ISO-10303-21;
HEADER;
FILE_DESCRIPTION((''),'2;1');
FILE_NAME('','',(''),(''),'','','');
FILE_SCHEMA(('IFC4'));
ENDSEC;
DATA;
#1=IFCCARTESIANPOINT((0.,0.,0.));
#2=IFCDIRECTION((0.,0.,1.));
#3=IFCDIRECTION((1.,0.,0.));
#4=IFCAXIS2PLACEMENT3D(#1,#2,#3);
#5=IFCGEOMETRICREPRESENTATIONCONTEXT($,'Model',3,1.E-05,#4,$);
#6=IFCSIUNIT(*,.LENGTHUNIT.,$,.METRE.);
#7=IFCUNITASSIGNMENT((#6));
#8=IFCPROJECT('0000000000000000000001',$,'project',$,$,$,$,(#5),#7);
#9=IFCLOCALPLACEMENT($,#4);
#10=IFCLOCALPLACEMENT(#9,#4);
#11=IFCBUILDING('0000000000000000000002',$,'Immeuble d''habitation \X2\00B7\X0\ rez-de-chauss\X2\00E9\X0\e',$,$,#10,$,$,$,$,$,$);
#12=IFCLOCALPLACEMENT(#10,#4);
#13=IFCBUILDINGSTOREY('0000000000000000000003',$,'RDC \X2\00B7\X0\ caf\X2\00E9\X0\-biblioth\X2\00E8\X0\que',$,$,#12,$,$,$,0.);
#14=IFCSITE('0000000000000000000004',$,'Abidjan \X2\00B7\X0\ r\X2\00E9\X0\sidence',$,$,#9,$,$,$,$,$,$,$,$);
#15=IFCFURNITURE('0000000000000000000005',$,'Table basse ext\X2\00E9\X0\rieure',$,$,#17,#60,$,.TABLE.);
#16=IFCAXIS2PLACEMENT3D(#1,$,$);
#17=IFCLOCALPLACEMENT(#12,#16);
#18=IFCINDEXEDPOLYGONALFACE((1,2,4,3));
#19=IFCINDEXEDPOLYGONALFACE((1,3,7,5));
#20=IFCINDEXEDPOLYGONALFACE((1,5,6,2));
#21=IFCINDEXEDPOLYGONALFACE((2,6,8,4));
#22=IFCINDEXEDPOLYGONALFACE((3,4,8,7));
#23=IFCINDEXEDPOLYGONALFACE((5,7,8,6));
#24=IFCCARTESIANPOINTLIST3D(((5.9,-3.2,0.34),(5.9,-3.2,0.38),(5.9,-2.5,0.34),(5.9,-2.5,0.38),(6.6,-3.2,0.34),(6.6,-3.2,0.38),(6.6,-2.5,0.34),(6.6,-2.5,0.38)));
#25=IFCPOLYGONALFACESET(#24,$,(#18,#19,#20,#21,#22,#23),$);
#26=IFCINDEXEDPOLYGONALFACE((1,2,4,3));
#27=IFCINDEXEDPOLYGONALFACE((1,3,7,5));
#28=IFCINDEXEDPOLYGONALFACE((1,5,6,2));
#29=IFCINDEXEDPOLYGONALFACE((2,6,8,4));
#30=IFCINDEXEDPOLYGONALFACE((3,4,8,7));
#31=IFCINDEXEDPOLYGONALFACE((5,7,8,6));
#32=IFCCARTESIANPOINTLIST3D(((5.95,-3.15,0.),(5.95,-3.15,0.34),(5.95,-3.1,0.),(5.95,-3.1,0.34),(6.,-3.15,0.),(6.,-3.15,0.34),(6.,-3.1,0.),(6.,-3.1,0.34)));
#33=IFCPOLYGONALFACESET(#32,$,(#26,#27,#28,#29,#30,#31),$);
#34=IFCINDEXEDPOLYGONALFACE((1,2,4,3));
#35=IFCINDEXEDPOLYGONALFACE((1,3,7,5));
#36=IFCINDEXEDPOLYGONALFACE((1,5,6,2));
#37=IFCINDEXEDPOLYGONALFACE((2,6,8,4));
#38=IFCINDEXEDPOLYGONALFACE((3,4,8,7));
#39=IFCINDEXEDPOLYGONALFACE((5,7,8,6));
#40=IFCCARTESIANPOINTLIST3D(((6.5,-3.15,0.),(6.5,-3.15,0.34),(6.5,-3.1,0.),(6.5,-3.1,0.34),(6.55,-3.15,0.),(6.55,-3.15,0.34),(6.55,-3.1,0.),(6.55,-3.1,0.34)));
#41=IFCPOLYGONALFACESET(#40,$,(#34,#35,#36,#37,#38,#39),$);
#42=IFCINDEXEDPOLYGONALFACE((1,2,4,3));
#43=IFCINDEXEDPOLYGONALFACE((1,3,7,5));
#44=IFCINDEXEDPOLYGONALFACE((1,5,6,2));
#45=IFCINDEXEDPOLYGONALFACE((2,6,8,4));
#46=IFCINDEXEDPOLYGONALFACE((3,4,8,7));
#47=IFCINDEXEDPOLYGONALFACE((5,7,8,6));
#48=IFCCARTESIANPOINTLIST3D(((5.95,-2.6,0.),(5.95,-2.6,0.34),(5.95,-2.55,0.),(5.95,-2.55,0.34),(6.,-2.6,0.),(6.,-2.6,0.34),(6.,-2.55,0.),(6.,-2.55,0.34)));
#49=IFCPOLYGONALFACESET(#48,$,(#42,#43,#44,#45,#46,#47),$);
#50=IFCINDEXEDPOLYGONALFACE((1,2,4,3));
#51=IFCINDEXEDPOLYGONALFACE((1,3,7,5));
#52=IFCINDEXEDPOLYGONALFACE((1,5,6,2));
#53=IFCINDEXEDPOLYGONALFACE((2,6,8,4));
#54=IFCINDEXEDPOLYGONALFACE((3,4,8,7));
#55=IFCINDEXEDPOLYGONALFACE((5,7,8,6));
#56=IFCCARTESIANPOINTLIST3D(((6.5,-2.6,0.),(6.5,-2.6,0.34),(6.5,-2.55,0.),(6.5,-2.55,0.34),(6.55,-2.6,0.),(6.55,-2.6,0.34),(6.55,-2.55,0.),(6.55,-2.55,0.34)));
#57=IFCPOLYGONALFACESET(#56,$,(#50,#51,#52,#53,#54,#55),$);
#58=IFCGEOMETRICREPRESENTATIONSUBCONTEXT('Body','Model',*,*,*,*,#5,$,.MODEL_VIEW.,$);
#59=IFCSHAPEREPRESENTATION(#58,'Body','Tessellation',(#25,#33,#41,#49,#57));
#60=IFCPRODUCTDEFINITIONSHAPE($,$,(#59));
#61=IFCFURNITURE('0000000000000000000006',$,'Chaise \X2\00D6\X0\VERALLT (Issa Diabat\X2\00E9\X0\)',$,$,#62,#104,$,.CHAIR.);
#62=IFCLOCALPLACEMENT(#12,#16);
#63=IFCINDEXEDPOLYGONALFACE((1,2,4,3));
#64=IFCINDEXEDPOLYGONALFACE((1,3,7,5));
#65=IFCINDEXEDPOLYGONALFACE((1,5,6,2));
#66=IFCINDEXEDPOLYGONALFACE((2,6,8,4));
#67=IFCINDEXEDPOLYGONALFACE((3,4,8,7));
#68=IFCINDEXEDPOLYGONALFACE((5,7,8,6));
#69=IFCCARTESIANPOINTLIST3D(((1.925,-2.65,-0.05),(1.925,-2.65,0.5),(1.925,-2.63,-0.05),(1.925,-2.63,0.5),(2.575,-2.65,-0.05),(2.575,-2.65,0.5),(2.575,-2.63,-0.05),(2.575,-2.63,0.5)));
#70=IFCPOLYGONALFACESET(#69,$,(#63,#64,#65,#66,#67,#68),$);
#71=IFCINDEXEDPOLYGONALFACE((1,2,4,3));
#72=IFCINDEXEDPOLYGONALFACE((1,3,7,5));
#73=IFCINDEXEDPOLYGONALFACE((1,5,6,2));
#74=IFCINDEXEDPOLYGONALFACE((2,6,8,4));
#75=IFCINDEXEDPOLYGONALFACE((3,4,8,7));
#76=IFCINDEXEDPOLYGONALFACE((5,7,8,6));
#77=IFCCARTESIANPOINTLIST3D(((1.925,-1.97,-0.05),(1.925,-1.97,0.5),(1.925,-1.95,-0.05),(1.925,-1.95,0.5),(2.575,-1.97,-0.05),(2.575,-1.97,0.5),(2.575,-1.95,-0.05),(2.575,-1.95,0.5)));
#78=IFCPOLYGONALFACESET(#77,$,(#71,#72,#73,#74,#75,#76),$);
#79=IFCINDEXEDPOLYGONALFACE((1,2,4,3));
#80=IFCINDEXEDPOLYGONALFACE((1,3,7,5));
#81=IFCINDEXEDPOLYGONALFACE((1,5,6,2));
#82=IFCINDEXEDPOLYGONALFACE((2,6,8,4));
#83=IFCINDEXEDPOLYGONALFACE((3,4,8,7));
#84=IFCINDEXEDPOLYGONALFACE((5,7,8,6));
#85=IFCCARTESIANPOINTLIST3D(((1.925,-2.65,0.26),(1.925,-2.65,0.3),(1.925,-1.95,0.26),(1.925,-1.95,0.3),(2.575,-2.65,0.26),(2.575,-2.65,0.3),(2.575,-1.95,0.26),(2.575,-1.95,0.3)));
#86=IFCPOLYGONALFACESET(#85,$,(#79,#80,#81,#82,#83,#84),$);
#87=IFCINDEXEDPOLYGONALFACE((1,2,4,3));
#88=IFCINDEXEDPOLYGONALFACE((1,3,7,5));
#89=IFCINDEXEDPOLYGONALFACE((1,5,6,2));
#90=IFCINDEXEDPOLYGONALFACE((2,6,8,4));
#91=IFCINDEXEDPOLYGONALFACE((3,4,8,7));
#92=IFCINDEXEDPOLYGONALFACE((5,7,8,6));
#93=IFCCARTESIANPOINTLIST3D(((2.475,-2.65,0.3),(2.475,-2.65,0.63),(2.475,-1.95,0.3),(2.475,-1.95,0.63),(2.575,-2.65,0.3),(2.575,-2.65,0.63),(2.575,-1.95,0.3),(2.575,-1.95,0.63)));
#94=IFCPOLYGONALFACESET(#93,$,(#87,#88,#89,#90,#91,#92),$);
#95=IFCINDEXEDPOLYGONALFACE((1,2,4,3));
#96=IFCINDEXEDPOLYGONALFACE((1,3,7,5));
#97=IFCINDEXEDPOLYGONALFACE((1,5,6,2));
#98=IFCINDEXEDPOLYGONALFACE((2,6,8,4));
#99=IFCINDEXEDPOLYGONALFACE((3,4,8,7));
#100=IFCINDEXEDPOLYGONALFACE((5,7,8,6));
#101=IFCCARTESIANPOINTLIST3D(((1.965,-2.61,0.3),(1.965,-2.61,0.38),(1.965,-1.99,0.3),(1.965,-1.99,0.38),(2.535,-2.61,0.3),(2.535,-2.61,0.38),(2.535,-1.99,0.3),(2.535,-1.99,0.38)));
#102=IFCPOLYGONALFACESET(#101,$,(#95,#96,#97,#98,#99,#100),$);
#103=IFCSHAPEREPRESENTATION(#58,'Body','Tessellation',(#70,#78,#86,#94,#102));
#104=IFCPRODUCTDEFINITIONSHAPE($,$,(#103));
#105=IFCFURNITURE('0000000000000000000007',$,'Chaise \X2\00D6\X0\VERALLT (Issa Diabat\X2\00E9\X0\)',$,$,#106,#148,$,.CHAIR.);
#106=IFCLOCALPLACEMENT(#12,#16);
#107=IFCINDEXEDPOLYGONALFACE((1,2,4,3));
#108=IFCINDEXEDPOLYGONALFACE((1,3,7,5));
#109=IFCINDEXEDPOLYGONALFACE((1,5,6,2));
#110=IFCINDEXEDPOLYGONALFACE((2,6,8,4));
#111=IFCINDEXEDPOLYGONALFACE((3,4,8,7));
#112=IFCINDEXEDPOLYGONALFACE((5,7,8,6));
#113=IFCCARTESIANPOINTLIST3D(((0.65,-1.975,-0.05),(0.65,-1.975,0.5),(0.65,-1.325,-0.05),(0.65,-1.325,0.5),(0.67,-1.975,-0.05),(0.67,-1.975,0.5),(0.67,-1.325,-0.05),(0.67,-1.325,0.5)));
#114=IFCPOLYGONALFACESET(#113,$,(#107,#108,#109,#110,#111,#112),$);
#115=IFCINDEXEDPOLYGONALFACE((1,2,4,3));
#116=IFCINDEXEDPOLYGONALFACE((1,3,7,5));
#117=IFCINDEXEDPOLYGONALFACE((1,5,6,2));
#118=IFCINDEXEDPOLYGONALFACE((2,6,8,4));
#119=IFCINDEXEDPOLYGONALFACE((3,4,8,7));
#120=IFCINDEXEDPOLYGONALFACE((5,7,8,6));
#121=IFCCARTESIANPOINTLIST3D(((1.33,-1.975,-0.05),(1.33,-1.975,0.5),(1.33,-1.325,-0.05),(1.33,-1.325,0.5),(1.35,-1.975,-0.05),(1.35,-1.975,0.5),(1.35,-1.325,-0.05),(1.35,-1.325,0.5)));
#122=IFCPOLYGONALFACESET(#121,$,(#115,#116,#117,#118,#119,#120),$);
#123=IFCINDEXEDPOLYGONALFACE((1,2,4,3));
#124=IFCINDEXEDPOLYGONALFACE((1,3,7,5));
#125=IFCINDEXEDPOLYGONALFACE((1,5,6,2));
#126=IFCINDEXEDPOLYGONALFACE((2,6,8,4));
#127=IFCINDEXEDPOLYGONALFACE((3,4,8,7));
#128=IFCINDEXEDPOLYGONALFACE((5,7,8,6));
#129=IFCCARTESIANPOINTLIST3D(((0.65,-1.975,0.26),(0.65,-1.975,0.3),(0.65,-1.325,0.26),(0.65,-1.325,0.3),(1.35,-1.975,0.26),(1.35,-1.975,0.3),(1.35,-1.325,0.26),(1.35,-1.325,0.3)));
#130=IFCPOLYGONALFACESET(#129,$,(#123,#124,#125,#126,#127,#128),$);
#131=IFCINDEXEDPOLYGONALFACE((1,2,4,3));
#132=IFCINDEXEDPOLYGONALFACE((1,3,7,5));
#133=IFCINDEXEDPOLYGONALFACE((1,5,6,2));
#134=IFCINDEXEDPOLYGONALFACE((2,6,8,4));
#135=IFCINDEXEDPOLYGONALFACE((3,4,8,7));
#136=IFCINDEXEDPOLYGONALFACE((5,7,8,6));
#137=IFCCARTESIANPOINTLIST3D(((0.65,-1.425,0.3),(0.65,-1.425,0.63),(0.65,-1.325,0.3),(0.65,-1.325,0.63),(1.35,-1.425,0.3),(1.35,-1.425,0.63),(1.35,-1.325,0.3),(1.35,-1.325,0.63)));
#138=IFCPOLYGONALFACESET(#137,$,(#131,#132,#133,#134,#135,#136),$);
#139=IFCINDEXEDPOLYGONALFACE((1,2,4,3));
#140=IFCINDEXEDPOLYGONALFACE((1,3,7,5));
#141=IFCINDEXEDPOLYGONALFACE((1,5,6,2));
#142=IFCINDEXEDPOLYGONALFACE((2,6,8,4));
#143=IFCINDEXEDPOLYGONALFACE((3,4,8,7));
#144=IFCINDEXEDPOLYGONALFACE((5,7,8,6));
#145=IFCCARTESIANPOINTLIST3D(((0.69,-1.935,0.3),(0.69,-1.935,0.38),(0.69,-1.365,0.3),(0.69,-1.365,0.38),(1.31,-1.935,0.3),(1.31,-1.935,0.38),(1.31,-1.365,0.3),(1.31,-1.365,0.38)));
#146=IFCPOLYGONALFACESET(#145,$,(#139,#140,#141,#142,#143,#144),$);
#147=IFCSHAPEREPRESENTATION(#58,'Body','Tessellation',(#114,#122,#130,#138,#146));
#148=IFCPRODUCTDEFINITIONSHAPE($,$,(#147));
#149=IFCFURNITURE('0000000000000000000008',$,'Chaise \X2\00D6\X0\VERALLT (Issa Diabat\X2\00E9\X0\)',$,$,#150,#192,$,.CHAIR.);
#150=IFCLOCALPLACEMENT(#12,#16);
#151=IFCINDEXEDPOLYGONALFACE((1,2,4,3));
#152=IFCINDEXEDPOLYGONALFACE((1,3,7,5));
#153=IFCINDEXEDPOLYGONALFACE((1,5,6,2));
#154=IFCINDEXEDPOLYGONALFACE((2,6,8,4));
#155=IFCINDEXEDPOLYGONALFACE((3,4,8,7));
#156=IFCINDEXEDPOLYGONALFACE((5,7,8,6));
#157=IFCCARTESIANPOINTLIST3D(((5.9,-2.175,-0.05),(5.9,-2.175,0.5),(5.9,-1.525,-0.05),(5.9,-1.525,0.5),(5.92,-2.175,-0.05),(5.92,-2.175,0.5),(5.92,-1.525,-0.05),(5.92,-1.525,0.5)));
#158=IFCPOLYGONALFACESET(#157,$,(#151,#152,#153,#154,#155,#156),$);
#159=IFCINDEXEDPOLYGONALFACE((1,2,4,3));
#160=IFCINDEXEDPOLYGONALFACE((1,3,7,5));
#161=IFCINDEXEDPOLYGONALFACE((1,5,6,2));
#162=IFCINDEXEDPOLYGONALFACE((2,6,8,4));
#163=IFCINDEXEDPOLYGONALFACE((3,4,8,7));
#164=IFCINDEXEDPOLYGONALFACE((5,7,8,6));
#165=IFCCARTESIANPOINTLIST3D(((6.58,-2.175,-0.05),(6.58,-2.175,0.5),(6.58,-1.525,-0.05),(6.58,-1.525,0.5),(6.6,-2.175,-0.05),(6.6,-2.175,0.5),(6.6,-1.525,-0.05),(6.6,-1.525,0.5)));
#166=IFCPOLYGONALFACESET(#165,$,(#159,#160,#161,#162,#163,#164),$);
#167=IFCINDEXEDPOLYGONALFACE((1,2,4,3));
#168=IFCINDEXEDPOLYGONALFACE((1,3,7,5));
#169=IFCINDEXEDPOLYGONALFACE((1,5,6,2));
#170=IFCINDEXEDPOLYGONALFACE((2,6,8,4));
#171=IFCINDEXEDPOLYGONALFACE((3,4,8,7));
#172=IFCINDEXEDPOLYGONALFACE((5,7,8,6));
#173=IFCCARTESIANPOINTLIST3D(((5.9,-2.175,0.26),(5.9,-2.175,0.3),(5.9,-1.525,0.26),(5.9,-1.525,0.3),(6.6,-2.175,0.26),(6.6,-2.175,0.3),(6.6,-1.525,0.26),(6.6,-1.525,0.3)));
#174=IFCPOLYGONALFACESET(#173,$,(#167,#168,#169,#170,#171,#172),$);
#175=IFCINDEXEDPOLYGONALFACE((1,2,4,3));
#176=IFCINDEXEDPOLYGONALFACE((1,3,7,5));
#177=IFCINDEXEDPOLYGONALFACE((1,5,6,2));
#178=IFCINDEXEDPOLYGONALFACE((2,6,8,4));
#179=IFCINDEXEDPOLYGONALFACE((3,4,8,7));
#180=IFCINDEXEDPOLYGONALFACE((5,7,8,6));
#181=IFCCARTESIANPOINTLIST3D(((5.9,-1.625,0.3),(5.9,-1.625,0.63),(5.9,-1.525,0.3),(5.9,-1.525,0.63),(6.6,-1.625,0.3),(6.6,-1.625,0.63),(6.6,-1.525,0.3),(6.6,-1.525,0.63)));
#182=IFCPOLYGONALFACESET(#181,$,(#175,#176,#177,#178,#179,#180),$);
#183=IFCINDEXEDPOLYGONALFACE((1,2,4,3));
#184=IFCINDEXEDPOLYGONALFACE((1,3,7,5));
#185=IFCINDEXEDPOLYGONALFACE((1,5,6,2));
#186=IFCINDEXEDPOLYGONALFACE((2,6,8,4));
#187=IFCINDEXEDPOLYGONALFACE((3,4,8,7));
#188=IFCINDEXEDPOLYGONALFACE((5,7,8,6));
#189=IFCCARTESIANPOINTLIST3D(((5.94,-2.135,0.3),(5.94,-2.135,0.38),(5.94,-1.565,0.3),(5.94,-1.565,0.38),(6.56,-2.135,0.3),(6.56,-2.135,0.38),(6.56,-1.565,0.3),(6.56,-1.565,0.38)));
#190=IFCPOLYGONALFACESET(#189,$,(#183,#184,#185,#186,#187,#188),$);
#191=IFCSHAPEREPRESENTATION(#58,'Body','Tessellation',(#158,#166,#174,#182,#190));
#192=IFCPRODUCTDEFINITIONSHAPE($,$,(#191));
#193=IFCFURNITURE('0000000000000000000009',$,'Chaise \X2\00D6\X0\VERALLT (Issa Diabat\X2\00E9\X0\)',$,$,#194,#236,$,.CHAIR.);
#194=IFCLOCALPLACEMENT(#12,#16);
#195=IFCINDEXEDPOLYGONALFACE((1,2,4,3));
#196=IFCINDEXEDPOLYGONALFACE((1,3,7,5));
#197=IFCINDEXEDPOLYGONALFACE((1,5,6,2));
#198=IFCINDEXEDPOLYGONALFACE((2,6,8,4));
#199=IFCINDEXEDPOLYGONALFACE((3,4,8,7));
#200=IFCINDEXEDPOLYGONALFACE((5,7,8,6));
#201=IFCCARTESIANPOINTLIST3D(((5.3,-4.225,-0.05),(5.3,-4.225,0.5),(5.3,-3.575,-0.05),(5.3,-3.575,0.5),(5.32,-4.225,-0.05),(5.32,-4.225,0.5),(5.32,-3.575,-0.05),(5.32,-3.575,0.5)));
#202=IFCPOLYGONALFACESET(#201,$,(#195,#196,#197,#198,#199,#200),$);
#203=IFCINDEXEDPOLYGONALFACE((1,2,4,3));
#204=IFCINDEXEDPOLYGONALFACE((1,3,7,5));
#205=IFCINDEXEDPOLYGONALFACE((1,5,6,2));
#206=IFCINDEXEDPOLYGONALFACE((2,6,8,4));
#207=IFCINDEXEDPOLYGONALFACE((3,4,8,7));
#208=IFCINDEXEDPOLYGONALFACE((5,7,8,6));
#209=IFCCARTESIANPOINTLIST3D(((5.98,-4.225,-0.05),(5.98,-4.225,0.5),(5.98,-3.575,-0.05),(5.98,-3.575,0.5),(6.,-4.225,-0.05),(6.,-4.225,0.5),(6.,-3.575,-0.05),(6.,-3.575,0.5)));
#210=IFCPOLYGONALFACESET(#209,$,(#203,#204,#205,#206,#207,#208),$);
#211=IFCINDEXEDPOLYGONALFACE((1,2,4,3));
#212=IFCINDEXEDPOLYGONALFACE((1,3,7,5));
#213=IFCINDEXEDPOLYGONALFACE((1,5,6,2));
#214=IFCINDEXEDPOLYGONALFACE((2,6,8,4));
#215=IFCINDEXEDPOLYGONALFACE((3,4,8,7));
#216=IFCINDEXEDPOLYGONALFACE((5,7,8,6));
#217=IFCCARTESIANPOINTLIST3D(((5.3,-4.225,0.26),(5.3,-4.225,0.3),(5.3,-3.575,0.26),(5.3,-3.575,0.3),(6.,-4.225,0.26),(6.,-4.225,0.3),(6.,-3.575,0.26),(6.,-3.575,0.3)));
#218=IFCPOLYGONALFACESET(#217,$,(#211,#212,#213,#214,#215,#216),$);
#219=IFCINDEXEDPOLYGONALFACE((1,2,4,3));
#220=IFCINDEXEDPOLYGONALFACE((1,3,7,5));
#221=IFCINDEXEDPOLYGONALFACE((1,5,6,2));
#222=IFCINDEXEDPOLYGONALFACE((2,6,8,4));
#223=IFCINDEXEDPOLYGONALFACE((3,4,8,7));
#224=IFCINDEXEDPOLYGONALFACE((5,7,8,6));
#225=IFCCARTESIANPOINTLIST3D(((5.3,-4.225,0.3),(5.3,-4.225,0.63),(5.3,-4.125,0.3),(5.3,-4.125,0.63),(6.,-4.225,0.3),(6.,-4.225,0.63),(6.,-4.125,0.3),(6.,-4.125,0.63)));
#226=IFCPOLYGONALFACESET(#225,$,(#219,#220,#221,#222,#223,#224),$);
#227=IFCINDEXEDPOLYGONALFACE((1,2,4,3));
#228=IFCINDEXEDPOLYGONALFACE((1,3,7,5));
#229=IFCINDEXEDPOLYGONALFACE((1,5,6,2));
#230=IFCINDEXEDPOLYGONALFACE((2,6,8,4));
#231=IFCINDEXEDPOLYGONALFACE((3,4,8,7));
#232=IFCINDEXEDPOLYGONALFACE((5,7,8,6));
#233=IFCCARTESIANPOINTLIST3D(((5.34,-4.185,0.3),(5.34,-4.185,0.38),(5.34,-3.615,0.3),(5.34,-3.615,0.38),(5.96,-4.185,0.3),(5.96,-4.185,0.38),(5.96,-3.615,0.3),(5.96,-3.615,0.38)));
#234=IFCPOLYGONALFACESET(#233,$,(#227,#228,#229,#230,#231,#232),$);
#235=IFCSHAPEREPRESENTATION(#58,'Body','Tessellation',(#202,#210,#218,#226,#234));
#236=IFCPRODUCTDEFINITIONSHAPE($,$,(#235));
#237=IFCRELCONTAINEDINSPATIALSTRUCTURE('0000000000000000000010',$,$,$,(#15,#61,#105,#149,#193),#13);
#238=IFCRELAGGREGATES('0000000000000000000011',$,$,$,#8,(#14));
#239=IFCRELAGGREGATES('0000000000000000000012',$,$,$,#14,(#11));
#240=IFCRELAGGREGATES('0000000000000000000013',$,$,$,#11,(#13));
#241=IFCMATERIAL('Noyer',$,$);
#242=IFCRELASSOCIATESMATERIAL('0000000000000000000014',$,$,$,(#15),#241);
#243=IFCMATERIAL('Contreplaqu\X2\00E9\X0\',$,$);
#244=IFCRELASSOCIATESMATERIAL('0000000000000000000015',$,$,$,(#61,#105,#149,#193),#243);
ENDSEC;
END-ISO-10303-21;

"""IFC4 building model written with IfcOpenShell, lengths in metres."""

from ifc_helpers import new_model, si_unit, frame, frame_2d, origin, origin_with_axes, place, context, subcontext, project, spatial, rectangle, extrude, material, element, save


model = new_model("IFC4")

# Units and contexts
model_context = context("Model", 3, precision=1e-05, world=origin_with_axes())
body_context = subcontext(model_context, "Body", "Model", "MODEL_VIEW")
ifc_project = project(units=[si_unit("LENGTHUNIT", "METRE")], contexts=[model_context])

# Site, building, storey
site_placement = place(None, origin_with_axes())
site = spatial("IfcSite", under=ifc_project, at=site_placement, Name="Abidjan · résidence")
building_placement = place(site_placement, origin_with_axes())
building = spatial("IfcBuilding", under=site, at=building_placement, Name="Immeuble d'habitation · rez-de-chaussée")
storey_placement = place(building_placement, origin_with_axes())
storey = spatial("IfcBuildingStorey", under=building, at=storey_placement, Name="RDC · café-bibliothèque", Elevation=0.0)

# Furniture
ifc_material_1 = material(Name="Noyer")
furniture_1_placement = place(storey_placement, origin_with_axes())
element("IfcFurniture", 1, at=furniture_1_placement, inside=storey, material=ifc_material_1, Name="Table basse extérieure", PredefinedType="TABLE", context=body_context, shape_type="SweptSolid", body=[
    extrude(rectangle(XDim=0.7, YDim=0.7, at=frame_2d((6.25, -2.85))), frame((0.0, 0.0, 0.34)), (0.0, 0.0, 1.0), 0.04),
    extrude(rectangle(XDim=0.05, YDim=0.05, at=frame_2d((5.975, -3.125))), origin(), (0.0, 0.0, 1.0), 0.34),
    extrude(rectangle(XDim=0.05, YDim=0.05, at=frame_2d((6.525, -3.125))), origin(), (0.0, 0.0, 1.0), 0.34),
    extrude(rectangle(XDim=0.05, YDim=0.05, at=frame_2d((5.975, -2.575))), origin(), (0.0, 0.0, 1.0), 0.34),
    extrude(rectangle(XDim=0.05, YDim=0.05, at=frame_2d((6.525, -2.575))), origin(), (0.0, 0.0, 1.0), 0.34),
])
ifc_material_2 = material(Name="Contreplaqué")
furniture_2_placement = place(storey_placement, origin_with_axes())
element("IfcFurniture", 2, at=furniture_2_placement, inside=storey, material=ifc_material_2, Name="Chaise ÖVERALLT (Issa Diabaté)", PredefinedType="CHAIR", context=body_context, shape_type="SweptSolid", body=[
    extrude(rectangle(XDim=0.65, YDim=0.02, at=frame_2d((2.25, -2.64))), frame((0.0, 0.0, -0.05)), (0.0, 0.0, 1.0), 0.55),
    extrude(rectangle(XDim=0.65, YDim=0.02, at=frame_2d((2.25, -1.96))), frame((0.0, 0.0, -0.05)), (0.0, 0.0, 1.0), 0.55),
    extrude(rectangle(XDim=0.65, YDim=0.7, at=frame_2d((2.25, -2.3))), frame((0.0, 0.0, 0.26)), (0.0, 0.0, 1.0), 0.04),
    extrude(rectangle(XDim=0.1, YDim=0.7, at=frame_2d((2.525, -2.3))), frame((0.0, 0.0, 0.3)), (0.0, 0.0, 1.0), 0.33),
    extrude(rectangle(XDim=0.57, YDim=0.62, at=frame_2d((2.25, -2.3))), frame((0.0, 0.0, 0.3)), (0.0, 0.0, 1.0), 0.08),
])
furniture_3_placement = place(storey_placement, origin_with_axes())
element("IfcFurniture", 3, at=furniture_3_placement, inside=storey, material=ifc_material_2, Name="Chaise ÖVERALLT (Issa Diabaté)", PredefinedType="CHAIR", context=body_context, shape_type="SweptSolid", body=[
    extrude(rectangle(XDim=0.02, YDim=0.65, at=frame_2d((0.66, -1.65))), frame((0.0, 0.0, -0.05)), (0.0, 0.0, 1.0), 0.55),
    extrude(rectangle(XDim=0.02, YDim=0.65, at=frame_2d((1.34, -1.65))), frame((0.0, 0.0, -0.05)), (0.0, 0.0, 1.0), 0.55),
    extrude(rectangle(XDim=0.7, YDim=0.65, at=frame_2d((1.0, -1.65))), frame((0.0, 0.0, 0.26)), (0.0, 0.0, 1.0), 0.04),
    extrude(rectangle(XDim=0.7, YDim=0.1, at=frame_2d((1.0, -1.375))), frame((0.0, 0.0, 0.3)), (0.0, 0.0, 1.0), 0.33),
    extrude(rectangle(XDim=0.62, YDim=0.57, at=frame_2d((1.0, -1.65))), frame((0.0, 0.0, 0.3)), (0.0, 0.0, 1.0), 0.08),
])
furniture_4_placement = place(storey_placement, origin_with_axes())
element("IfcFurniture", 4, at=furniture_4_placement, inside=storey, material=ifc_material_2, Name="Chaise ÖVERALLT (Issa Diabaté)", PredefinedType="CHAIR", context=body_context, shape_type="SweptSolid", body=[
    extrude(rectangle(XDim=0.02, YDim=0.65, at=frame_2d((5.91, -1.85))), frame((0.0, 0.0, -0.05)), (0.0, 0.0, 1.0), 0.55),
    extrude(rectangle(XDim=0.02, YDim=0.65, at=frame_2d((6.59, -1.85))), frame((0.0, 0.0, -0.05)), (0.0, 0.0, 1.0), 0.55),
    extrude(rectangle(XDim=0.7, YDim=0.65, at=frame_2d((6.25, -1.85))), frame((0.0, 0.0, 0.26)), (0.0, 0.0, 1.0), 0.04),
    extrude(rectangle(XDim=0.7, YDim=0.1, at=frame_2d((6.25, -1.575))), frame((0.0, 0.0, 0.3)), (0.0, 0.0, 1.0), 0.33),
    extrude(rectangle(XDim=0.62, YDim=0.57, at=frame_2d((6.25, -1.85))), frame((0.0, 0.0, 0.3)), (0.0, 0.0, 1.0), 0.08),
])
furniture_5_placement = place(storey_placement, origin_with_axes())
element("IfcFurniture", 5, at=furniture_5_placement, inside=storey, material=ifc_material_2, Name="Chaise ÖVERALLT (Issa Diabaté)", PredefinedType="CHAIR", context=body_context, shape_type="SweptSolid", body=[
    extrude(rectangle(XDim=0.02, YDim=0.65, at=frame_2d((5.31, -3.9))), frame((0.0, 0.0, -0.05)), (0.0, 0.0, 1.0), 0.55),
    extrude(rectangle(XDim=0.02, YDim=0.65, at=frame_2d((5.99, -3.9))), frame((0.0, 0.0, -0.05)), (0.0, 0.0, 1.0), 0.55),
    extrude(rectangle(XDim=0.7, YDim=0.65, at=frame_2d((5.65, -3.9))), frame((0.0, 0.0, 0.26)), (0.0, 0.0, 1.0), 0.04),
    extrude(rectangle(XDim=0.7, YDim=0.1, at=frame_2d((5.65, -4.175))), frame((0.0, 0.0, 0.3)), (0.0, 0.0, 1.0), 0.33),
    extrude(rectangle(XDim=0.62, YDim=0.57, at=frame_2d((5.65, -3.9))), frame((0.0, 0.0, 0.3)), (0.0, 0.0, 1.0), 0.08),
])

save(model, "model.ifc")
